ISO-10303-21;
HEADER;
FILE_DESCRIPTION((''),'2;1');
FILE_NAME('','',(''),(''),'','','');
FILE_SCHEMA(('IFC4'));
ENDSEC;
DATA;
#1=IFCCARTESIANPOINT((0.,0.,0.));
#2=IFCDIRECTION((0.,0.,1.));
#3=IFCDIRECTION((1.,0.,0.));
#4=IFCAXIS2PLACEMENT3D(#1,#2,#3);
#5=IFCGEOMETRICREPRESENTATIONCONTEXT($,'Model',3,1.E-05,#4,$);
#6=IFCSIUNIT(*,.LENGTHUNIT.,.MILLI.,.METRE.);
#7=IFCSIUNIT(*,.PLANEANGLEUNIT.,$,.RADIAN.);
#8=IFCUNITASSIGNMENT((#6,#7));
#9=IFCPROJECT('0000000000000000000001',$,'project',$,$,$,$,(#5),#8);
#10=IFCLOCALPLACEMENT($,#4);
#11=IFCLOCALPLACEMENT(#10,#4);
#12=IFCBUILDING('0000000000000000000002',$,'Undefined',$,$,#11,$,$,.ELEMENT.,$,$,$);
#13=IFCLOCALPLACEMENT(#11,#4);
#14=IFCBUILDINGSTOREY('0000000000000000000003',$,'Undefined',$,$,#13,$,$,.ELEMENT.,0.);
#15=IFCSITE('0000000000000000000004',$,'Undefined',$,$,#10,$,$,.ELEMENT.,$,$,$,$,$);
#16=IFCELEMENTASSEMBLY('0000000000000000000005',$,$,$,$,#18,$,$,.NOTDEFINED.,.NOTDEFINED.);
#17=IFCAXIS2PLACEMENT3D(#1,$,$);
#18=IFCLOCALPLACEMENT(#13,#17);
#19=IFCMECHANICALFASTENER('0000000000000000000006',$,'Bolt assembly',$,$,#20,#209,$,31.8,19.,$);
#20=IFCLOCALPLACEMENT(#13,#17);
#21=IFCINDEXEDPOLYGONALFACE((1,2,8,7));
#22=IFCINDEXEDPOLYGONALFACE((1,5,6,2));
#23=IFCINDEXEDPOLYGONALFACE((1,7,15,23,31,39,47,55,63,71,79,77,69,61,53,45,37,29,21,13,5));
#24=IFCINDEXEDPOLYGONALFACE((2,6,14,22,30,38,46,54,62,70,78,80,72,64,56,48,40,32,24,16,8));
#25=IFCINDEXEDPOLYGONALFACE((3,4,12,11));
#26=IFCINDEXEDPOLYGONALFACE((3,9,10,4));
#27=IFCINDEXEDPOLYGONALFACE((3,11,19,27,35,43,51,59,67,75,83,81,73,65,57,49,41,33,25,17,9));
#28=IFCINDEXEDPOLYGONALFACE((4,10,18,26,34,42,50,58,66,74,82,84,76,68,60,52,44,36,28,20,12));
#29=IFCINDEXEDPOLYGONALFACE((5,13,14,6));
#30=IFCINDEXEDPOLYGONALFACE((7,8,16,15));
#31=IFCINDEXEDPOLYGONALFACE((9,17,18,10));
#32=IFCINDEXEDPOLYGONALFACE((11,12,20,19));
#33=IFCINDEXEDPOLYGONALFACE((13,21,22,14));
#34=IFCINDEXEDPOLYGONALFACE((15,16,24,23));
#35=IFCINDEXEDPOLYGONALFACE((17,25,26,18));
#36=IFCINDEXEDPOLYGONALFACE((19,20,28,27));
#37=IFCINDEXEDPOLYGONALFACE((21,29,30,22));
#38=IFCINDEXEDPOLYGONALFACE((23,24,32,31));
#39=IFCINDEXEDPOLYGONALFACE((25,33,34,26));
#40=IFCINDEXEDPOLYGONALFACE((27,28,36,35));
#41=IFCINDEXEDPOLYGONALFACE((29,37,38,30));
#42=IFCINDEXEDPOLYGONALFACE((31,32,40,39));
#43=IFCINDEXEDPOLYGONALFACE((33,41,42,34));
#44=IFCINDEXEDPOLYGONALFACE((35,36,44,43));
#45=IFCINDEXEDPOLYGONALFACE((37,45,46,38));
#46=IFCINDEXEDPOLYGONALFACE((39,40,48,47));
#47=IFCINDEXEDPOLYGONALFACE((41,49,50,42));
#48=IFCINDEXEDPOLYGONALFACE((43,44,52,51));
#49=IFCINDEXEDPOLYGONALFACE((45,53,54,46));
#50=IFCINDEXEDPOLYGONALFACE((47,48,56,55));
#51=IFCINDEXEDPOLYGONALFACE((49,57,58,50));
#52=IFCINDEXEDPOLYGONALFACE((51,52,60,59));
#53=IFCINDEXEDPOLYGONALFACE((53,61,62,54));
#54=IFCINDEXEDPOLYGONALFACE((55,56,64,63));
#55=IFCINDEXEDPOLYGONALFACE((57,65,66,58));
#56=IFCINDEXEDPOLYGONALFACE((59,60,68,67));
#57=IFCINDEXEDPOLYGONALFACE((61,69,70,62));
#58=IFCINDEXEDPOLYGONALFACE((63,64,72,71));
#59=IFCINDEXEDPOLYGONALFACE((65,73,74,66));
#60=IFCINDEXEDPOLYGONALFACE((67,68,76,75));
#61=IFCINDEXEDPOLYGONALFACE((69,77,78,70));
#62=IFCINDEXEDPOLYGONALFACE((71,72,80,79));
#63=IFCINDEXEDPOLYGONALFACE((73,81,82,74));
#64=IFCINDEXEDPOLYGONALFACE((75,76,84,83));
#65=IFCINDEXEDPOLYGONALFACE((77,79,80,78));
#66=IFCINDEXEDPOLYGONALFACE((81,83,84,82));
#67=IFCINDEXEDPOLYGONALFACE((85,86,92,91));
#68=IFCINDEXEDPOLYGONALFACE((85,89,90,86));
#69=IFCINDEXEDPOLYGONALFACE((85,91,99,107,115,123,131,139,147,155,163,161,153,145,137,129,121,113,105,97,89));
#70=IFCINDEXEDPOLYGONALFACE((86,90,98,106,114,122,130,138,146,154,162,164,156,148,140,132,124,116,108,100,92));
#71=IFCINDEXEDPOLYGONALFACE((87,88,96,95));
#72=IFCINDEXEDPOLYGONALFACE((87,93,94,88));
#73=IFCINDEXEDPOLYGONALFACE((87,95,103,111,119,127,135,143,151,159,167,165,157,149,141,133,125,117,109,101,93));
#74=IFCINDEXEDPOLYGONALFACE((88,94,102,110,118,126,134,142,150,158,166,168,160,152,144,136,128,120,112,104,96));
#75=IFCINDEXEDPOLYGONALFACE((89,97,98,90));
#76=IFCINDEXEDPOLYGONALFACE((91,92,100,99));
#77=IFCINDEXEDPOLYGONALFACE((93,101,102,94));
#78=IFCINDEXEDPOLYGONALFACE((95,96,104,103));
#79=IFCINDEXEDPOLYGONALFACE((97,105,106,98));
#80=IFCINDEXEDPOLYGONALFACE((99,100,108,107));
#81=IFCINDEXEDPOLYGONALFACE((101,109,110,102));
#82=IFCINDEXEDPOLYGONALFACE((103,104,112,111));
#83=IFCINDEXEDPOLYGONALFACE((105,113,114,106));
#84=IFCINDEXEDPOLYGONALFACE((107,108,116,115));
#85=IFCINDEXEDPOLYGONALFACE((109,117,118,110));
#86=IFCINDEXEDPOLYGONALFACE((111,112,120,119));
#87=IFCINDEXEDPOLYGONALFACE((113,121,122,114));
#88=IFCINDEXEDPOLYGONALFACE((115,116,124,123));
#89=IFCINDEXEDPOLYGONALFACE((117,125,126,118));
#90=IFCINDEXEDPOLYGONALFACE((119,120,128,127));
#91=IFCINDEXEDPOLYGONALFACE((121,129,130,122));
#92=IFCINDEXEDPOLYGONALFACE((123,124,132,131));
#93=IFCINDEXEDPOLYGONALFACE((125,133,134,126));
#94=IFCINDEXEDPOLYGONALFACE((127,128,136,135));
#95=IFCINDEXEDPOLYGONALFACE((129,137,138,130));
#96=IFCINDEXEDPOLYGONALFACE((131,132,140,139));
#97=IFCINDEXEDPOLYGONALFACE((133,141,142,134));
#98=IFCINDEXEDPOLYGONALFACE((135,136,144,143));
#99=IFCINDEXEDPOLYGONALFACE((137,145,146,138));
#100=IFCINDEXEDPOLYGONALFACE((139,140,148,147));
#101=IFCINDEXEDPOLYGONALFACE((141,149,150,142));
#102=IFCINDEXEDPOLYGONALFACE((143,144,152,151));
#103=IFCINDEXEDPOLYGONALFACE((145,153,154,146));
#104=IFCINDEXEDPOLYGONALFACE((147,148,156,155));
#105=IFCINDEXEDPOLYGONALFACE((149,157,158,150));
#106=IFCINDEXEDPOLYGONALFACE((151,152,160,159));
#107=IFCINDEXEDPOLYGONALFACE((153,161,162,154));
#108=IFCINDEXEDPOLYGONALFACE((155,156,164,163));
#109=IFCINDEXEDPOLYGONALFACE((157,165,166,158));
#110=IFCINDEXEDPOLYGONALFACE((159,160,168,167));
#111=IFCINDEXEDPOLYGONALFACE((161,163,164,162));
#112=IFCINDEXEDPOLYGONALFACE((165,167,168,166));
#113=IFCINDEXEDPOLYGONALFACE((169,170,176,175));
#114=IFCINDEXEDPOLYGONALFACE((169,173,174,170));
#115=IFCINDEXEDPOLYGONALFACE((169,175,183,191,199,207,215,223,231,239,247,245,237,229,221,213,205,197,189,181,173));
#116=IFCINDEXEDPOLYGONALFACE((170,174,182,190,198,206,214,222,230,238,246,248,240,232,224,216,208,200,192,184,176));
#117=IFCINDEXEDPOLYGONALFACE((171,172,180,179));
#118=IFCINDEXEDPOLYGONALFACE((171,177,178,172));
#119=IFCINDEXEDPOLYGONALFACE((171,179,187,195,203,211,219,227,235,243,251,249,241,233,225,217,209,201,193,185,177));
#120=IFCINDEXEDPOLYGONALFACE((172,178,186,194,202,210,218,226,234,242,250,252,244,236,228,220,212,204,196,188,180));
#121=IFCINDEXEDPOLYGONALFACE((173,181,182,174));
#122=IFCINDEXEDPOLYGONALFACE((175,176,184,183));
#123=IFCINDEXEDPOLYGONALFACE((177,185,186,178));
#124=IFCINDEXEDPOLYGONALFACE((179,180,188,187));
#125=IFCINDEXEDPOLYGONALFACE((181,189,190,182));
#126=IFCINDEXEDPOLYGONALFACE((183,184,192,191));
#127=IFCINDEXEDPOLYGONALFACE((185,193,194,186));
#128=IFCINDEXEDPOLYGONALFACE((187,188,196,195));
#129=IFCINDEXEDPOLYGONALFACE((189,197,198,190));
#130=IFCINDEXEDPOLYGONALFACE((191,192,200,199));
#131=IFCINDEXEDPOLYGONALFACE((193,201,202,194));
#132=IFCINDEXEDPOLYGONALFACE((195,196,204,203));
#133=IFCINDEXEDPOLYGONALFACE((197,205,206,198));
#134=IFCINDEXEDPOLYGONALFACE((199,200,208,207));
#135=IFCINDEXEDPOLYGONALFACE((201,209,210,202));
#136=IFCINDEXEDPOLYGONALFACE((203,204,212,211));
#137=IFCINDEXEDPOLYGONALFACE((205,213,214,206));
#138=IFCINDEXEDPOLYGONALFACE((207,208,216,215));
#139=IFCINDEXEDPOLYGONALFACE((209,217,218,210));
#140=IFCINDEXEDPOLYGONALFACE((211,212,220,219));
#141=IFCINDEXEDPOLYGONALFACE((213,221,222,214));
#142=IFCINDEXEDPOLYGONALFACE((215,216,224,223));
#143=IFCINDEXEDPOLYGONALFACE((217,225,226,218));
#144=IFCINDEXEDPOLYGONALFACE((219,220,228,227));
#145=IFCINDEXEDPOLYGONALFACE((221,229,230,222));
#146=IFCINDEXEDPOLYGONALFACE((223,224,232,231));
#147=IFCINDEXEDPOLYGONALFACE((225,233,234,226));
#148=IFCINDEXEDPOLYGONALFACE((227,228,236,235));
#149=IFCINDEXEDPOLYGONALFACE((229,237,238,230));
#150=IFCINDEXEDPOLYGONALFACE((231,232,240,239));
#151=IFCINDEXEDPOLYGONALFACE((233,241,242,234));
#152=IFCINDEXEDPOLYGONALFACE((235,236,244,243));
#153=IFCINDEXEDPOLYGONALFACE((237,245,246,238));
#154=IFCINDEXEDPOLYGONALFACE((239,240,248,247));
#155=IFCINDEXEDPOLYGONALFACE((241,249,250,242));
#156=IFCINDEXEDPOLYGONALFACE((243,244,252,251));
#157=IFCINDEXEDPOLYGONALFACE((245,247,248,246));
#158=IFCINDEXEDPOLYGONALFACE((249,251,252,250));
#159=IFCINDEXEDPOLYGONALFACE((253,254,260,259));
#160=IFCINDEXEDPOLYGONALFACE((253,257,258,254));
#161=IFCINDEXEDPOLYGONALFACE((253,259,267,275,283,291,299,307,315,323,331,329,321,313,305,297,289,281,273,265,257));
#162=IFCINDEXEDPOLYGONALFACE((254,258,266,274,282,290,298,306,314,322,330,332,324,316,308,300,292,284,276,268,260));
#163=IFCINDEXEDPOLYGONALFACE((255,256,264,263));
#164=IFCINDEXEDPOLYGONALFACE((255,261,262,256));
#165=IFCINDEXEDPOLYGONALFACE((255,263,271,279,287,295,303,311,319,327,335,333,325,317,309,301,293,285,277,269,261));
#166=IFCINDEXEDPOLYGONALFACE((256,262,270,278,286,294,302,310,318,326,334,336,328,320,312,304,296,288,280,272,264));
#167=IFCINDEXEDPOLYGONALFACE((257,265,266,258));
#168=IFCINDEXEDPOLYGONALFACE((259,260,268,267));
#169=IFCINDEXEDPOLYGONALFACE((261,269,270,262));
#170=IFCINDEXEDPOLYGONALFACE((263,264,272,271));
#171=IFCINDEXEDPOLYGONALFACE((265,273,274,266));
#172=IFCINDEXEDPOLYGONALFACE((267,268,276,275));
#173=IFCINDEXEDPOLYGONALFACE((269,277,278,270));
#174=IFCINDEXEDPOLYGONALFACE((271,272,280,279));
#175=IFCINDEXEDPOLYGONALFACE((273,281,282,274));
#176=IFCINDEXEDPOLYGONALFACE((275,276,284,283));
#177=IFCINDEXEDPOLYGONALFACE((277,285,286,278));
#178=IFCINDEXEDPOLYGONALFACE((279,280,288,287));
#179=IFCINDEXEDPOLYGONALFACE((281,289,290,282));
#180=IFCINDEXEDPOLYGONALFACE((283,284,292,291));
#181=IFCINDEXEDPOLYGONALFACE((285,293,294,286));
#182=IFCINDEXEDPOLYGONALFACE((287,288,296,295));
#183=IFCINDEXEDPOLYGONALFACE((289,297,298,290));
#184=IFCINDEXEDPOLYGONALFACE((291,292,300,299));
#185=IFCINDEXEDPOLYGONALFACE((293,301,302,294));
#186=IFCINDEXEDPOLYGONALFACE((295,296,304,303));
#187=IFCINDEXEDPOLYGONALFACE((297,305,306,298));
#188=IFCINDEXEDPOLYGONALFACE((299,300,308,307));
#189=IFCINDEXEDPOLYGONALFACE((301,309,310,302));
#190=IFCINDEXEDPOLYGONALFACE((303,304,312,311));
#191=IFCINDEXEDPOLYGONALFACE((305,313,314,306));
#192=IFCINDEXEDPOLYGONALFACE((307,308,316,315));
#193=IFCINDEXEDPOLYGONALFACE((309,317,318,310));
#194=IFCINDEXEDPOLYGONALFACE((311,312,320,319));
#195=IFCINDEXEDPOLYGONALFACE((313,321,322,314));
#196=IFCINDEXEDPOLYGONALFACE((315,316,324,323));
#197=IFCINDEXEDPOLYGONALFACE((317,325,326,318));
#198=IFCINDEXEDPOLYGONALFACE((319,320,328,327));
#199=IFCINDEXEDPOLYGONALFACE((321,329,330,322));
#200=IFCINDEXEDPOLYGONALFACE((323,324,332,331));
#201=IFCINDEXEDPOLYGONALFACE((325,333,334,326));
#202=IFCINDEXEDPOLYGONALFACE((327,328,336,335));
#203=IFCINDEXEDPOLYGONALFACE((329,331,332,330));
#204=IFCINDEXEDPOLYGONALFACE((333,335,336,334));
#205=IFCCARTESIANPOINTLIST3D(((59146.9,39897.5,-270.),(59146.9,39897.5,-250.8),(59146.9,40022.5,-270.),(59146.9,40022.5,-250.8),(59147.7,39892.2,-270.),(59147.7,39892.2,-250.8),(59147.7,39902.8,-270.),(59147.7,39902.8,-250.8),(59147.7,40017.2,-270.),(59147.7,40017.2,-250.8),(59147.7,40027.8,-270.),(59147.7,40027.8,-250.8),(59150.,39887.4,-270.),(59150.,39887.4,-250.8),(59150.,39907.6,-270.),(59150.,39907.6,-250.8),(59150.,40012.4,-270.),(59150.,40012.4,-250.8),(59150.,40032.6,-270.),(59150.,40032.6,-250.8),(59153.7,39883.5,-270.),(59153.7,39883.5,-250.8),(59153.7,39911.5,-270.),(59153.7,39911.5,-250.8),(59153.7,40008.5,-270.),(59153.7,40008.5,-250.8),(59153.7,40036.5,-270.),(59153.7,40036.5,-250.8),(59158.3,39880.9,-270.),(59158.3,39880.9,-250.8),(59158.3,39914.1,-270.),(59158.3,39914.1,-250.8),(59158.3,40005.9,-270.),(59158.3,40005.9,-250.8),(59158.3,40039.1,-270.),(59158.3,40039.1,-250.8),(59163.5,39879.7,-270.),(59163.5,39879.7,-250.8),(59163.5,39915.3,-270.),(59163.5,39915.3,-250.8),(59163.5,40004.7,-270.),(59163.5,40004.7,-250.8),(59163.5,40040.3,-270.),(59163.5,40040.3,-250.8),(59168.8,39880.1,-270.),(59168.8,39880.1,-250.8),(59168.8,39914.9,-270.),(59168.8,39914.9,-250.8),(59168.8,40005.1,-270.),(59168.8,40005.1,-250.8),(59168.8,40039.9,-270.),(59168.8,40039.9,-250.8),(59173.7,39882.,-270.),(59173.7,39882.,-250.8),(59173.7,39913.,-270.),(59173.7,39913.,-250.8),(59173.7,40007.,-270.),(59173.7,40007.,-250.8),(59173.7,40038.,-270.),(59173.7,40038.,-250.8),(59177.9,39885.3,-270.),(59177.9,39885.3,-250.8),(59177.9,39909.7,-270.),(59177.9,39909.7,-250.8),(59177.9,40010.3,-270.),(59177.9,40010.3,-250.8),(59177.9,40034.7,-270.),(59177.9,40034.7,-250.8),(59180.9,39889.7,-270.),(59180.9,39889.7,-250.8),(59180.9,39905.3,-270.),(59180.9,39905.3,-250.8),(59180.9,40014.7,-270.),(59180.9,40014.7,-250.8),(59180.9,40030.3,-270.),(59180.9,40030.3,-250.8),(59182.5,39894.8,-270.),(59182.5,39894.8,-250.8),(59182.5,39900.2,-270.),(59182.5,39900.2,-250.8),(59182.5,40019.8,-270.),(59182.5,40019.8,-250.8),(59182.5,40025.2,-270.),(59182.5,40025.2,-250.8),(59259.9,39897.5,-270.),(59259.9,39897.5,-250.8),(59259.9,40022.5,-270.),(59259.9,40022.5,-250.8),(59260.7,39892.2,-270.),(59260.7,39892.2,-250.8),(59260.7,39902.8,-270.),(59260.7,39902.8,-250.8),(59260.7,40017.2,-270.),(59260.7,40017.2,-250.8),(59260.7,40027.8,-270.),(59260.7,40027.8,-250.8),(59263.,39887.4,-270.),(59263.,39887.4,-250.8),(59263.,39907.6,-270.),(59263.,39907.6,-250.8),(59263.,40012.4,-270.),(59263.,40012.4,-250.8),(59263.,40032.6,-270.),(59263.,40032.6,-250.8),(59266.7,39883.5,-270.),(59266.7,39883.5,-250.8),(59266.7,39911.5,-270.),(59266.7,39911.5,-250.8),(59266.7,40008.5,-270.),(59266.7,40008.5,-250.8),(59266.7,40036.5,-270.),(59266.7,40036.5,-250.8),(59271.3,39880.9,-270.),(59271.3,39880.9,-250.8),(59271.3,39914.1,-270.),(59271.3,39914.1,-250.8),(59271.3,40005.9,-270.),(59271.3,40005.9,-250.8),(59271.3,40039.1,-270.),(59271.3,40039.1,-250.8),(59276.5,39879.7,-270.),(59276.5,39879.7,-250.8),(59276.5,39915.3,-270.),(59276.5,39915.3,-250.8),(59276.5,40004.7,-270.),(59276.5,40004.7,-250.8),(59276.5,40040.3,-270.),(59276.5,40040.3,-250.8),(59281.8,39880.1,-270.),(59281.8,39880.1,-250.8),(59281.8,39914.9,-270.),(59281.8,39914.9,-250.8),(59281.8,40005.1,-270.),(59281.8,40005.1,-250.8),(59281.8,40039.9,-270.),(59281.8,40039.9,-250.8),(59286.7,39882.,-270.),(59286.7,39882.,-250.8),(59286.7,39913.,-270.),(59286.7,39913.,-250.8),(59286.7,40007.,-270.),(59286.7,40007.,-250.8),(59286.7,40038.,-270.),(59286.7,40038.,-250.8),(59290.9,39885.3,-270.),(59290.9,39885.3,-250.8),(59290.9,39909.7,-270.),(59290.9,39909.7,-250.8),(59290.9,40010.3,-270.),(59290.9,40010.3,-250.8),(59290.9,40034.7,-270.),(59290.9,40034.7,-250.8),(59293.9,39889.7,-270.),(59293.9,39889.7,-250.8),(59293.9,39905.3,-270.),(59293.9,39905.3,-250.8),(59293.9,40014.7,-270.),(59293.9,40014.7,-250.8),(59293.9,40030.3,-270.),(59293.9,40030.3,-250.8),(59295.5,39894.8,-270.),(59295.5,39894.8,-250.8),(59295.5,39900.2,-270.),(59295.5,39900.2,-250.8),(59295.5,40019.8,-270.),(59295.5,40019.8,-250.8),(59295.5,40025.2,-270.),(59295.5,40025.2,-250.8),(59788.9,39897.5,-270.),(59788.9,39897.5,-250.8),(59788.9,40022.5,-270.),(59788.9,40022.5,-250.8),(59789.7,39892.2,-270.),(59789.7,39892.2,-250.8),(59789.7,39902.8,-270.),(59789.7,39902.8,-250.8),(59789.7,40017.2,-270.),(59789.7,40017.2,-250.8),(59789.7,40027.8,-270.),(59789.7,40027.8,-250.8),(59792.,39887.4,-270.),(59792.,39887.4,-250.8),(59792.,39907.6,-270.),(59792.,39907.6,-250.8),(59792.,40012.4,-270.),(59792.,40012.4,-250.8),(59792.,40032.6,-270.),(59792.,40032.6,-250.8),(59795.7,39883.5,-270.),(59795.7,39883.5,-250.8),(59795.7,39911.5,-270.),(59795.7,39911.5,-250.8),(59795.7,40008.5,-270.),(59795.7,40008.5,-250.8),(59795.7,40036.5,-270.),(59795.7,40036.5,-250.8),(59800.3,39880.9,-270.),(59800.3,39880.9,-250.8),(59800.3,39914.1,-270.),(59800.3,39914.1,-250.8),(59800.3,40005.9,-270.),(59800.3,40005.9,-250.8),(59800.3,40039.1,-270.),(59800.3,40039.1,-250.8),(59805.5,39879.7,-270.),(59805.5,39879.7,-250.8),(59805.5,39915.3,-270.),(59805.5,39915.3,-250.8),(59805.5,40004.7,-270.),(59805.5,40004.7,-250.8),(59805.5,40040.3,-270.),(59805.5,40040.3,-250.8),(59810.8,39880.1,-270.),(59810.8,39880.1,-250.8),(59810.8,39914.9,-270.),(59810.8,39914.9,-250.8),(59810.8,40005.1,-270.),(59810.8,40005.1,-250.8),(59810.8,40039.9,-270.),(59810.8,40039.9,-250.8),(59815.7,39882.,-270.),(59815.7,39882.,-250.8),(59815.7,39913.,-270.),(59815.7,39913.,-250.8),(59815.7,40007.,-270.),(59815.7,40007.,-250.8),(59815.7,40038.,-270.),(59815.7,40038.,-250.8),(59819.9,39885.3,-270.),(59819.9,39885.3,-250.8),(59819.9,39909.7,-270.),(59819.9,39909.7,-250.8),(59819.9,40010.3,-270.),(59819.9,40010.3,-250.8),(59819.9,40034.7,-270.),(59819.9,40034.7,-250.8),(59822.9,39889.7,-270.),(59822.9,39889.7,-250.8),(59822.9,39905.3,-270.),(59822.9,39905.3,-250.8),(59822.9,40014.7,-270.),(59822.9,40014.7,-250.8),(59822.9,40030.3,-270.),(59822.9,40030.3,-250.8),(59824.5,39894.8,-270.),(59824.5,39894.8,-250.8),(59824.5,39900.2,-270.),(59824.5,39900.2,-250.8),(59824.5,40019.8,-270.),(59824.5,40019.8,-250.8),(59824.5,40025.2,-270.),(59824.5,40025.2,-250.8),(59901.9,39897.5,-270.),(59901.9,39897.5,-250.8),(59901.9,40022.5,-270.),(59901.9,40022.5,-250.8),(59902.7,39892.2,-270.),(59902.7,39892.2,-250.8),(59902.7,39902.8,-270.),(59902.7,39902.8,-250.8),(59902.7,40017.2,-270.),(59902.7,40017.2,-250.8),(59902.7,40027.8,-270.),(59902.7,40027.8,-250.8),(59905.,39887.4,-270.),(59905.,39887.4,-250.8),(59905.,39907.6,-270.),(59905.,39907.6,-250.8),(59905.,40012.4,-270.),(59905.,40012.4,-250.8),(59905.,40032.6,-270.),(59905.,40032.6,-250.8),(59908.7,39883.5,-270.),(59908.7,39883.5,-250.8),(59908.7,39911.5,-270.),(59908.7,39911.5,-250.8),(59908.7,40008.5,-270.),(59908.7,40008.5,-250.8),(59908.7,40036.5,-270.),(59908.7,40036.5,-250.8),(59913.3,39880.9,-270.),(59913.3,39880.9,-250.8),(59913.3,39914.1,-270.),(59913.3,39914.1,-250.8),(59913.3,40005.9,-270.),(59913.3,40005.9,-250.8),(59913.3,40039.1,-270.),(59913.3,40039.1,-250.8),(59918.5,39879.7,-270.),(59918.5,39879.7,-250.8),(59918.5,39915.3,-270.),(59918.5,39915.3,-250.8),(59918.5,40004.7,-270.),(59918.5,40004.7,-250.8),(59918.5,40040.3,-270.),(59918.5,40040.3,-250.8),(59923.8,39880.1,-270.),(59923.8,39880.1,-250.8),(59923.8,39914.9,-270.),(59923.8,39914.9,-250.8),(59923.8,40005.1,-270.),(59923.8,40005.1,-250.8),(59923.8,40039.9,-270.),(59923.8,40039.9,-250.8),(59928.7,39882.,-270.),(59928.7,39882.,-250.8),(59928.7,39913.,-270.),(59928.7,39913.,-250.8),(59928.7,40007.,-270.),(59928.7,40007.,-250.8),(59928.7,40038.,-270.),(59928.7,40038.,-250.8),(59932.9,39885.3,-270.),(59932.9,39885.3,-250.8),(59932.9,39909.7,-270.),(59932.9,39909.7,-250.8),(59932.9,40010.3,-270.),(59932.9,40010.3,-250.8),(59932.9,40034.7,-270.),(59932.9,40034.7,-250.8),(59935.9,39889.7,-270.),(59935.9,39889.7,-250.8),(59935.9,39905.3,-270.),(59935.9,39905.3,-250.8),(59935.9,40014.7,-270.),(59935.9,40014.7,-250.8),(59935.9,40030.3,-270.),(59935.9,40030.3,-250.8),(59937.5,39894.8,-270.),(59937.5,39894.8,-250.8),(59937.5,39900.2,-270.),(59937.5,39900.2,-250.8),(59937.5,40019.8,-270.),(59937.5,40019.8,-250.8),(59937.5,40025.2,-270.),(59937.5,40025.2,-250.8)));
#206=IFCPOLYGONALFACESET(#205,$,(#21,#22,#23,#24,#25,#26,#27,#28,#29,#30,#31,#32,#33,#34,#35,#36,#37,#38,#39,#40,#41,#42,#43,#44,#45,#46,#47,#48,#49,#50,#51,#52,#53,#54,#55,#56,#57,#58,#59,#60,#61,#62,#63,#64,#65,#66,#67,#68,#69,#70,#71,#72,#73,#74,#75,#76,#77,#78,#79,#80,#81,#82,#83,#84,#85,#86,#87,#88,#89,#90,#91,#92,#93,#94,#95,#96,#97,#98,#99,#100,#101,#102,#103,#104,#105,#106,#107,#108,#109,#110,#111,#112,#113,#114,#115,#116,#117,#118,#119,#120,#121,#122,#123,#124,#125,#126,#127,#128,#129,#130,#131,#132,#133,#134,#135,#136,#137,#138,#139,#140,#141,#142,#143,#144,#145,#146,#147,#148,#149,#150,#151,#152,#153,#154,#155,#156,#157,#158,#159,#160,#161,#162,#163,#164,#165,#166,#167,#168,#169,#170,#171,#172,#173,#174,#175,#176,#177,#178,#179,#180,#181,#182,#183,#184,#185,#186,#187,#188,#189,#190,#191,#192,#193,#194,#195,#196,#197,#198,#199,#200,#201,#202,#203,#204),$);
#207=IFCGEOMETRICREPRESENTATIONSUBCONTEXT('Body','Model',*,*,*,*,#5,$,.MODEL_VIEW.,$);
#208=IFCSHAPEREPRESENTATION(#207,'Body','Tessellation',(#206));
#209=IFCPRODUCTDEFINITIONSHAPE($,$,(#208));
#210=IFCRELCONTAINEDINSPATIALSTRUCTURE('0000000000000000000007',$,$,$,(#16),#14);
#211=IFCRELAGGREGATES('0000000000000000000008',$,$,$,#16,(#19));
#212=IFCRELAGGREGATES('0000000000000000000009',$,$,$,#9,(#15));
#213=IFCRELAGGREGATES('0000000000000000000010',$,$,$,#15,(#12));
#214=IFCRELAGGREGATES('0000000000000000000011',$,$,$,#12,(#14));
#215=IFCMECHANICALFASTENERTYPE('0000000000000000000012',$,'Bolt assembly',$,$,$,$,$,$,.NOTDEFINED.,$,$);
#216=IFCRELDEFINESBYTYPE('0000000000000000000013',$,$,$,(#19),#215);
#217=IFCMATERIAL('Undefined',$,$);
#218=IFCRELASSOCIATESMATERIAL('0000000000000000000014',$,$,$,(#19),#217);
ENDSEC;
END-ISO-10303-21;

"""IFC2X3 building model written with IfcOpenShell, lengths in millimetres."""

from ifc_helpers import new_model, si_unit, frame, origin_with_axes, origin_2d_with_axis, place, context, subcontext, project, spatial, circle, extrude, source, transform, mapped, material, type_object, element, aggregate, save


model = new_model("IFC2X3")

# Units and contexts
model_context = context("Model", 3, precision=1e-05, world=origin_with_axes())
body_context = subcontext(model_context, "Body", "Model", "MODEL_VIEW")
ifc_project = project(units=[si_unit("LENGTHUNIT", "METRE", prefix="MILLI"), si_unit("PLANEANGLEUNIT", "RADIAN")], contexts=[model_context])

# Site, building, storey
site_placement = place(None, origin_with_axes())
site = spatial("IfcSite", under=ifc_project, at=site_placement, Name="Undefined", CompositionType="ELEMENT")
building_placement = place(site_placement, origin_with_axes())
building = spatial("IfcBuilding", under=site, at=building_placement, Name="Undefined", CompositionType="ELEMENT")
storey_placement = place(building_placement, origin_with_axes())
storey = spatial("IfcBuildingStorey", under=building, at=storey_placement, Name="Undefined", CompositionType="ELEMENT", Elevation=0.0)

# Element assembly
assembly_1_placement = place(storey_placement, origin_with_axes())
assembly_1 = element("IfcElementAssembly", 1, at=assembly_1_placement, inside=storey, AssemblyPlace="NOTDEFINED", PredefinedType="NOTDEFINED")

# Shared definitions
ifc_material_1 = material(Name="Undefined")
mechanical_fastener_type = type_object("IfcMechanicalFastenerType", Name="Bolt assembly")

# Mechanical fastener
shared_shape_1 = source(origin_with_axes(), body_context, "Body", "SweptSolid", [
    extrude(circle(Radius=17.9, at=origin_2d_with_axis()), frame((0.0, 0.0, 0.0), z_axis=(0.0, 1.0, 0.0), x_axis=(1.0, 0.0, 0.0)), (0.0, 0.0, 1.0), 19.1),
])
mechanical_fastener_1_placement = place(assembly_1_placement, frame((59919.8, 39960.0, -270.0), z_axis=(0.0, 1.0, 0.0), x_axis=(-1.0, 0.0, 0.0)))
mechanical_fastener_1 = element("IfcMechanicalFastener", 2, at=mechanical_fastener_1_placement, type_object=mechanical_fastener_type, material=ifc_material_1, Name="Bolt assembly", NominalDiameter=31.8, NominalLength=19.0, context=body_context, shape_type="MappedRepresentation", body=[
    mapped(shared_shape_1, transform((0.0, 0.0, -62.5))),
    mapped(shared_shape_1, transform((113.0, 0.0, -62.5))),
    mapped(shared_shape_1, transform((642.0, 0.0, -62.5))),
    mapped(shared_shape_1, transform((755.0, 0.0, -62.5))),
    mapped(shared_shape_1, transform((0.0, 0.0, 62.5))),
    mapped(shared_shape_1, transform((113.0, 0.0, 62.5))),
    mapped(shared_shape_1, transform((642.0, 0.0, 62.5))),
    mapped(shared_shape_1, transform((755.0, 0.0, 62.5))),
])
aggregate(assembly_1, [mechanical_fastener_1])

save(model, "model.ifc")
